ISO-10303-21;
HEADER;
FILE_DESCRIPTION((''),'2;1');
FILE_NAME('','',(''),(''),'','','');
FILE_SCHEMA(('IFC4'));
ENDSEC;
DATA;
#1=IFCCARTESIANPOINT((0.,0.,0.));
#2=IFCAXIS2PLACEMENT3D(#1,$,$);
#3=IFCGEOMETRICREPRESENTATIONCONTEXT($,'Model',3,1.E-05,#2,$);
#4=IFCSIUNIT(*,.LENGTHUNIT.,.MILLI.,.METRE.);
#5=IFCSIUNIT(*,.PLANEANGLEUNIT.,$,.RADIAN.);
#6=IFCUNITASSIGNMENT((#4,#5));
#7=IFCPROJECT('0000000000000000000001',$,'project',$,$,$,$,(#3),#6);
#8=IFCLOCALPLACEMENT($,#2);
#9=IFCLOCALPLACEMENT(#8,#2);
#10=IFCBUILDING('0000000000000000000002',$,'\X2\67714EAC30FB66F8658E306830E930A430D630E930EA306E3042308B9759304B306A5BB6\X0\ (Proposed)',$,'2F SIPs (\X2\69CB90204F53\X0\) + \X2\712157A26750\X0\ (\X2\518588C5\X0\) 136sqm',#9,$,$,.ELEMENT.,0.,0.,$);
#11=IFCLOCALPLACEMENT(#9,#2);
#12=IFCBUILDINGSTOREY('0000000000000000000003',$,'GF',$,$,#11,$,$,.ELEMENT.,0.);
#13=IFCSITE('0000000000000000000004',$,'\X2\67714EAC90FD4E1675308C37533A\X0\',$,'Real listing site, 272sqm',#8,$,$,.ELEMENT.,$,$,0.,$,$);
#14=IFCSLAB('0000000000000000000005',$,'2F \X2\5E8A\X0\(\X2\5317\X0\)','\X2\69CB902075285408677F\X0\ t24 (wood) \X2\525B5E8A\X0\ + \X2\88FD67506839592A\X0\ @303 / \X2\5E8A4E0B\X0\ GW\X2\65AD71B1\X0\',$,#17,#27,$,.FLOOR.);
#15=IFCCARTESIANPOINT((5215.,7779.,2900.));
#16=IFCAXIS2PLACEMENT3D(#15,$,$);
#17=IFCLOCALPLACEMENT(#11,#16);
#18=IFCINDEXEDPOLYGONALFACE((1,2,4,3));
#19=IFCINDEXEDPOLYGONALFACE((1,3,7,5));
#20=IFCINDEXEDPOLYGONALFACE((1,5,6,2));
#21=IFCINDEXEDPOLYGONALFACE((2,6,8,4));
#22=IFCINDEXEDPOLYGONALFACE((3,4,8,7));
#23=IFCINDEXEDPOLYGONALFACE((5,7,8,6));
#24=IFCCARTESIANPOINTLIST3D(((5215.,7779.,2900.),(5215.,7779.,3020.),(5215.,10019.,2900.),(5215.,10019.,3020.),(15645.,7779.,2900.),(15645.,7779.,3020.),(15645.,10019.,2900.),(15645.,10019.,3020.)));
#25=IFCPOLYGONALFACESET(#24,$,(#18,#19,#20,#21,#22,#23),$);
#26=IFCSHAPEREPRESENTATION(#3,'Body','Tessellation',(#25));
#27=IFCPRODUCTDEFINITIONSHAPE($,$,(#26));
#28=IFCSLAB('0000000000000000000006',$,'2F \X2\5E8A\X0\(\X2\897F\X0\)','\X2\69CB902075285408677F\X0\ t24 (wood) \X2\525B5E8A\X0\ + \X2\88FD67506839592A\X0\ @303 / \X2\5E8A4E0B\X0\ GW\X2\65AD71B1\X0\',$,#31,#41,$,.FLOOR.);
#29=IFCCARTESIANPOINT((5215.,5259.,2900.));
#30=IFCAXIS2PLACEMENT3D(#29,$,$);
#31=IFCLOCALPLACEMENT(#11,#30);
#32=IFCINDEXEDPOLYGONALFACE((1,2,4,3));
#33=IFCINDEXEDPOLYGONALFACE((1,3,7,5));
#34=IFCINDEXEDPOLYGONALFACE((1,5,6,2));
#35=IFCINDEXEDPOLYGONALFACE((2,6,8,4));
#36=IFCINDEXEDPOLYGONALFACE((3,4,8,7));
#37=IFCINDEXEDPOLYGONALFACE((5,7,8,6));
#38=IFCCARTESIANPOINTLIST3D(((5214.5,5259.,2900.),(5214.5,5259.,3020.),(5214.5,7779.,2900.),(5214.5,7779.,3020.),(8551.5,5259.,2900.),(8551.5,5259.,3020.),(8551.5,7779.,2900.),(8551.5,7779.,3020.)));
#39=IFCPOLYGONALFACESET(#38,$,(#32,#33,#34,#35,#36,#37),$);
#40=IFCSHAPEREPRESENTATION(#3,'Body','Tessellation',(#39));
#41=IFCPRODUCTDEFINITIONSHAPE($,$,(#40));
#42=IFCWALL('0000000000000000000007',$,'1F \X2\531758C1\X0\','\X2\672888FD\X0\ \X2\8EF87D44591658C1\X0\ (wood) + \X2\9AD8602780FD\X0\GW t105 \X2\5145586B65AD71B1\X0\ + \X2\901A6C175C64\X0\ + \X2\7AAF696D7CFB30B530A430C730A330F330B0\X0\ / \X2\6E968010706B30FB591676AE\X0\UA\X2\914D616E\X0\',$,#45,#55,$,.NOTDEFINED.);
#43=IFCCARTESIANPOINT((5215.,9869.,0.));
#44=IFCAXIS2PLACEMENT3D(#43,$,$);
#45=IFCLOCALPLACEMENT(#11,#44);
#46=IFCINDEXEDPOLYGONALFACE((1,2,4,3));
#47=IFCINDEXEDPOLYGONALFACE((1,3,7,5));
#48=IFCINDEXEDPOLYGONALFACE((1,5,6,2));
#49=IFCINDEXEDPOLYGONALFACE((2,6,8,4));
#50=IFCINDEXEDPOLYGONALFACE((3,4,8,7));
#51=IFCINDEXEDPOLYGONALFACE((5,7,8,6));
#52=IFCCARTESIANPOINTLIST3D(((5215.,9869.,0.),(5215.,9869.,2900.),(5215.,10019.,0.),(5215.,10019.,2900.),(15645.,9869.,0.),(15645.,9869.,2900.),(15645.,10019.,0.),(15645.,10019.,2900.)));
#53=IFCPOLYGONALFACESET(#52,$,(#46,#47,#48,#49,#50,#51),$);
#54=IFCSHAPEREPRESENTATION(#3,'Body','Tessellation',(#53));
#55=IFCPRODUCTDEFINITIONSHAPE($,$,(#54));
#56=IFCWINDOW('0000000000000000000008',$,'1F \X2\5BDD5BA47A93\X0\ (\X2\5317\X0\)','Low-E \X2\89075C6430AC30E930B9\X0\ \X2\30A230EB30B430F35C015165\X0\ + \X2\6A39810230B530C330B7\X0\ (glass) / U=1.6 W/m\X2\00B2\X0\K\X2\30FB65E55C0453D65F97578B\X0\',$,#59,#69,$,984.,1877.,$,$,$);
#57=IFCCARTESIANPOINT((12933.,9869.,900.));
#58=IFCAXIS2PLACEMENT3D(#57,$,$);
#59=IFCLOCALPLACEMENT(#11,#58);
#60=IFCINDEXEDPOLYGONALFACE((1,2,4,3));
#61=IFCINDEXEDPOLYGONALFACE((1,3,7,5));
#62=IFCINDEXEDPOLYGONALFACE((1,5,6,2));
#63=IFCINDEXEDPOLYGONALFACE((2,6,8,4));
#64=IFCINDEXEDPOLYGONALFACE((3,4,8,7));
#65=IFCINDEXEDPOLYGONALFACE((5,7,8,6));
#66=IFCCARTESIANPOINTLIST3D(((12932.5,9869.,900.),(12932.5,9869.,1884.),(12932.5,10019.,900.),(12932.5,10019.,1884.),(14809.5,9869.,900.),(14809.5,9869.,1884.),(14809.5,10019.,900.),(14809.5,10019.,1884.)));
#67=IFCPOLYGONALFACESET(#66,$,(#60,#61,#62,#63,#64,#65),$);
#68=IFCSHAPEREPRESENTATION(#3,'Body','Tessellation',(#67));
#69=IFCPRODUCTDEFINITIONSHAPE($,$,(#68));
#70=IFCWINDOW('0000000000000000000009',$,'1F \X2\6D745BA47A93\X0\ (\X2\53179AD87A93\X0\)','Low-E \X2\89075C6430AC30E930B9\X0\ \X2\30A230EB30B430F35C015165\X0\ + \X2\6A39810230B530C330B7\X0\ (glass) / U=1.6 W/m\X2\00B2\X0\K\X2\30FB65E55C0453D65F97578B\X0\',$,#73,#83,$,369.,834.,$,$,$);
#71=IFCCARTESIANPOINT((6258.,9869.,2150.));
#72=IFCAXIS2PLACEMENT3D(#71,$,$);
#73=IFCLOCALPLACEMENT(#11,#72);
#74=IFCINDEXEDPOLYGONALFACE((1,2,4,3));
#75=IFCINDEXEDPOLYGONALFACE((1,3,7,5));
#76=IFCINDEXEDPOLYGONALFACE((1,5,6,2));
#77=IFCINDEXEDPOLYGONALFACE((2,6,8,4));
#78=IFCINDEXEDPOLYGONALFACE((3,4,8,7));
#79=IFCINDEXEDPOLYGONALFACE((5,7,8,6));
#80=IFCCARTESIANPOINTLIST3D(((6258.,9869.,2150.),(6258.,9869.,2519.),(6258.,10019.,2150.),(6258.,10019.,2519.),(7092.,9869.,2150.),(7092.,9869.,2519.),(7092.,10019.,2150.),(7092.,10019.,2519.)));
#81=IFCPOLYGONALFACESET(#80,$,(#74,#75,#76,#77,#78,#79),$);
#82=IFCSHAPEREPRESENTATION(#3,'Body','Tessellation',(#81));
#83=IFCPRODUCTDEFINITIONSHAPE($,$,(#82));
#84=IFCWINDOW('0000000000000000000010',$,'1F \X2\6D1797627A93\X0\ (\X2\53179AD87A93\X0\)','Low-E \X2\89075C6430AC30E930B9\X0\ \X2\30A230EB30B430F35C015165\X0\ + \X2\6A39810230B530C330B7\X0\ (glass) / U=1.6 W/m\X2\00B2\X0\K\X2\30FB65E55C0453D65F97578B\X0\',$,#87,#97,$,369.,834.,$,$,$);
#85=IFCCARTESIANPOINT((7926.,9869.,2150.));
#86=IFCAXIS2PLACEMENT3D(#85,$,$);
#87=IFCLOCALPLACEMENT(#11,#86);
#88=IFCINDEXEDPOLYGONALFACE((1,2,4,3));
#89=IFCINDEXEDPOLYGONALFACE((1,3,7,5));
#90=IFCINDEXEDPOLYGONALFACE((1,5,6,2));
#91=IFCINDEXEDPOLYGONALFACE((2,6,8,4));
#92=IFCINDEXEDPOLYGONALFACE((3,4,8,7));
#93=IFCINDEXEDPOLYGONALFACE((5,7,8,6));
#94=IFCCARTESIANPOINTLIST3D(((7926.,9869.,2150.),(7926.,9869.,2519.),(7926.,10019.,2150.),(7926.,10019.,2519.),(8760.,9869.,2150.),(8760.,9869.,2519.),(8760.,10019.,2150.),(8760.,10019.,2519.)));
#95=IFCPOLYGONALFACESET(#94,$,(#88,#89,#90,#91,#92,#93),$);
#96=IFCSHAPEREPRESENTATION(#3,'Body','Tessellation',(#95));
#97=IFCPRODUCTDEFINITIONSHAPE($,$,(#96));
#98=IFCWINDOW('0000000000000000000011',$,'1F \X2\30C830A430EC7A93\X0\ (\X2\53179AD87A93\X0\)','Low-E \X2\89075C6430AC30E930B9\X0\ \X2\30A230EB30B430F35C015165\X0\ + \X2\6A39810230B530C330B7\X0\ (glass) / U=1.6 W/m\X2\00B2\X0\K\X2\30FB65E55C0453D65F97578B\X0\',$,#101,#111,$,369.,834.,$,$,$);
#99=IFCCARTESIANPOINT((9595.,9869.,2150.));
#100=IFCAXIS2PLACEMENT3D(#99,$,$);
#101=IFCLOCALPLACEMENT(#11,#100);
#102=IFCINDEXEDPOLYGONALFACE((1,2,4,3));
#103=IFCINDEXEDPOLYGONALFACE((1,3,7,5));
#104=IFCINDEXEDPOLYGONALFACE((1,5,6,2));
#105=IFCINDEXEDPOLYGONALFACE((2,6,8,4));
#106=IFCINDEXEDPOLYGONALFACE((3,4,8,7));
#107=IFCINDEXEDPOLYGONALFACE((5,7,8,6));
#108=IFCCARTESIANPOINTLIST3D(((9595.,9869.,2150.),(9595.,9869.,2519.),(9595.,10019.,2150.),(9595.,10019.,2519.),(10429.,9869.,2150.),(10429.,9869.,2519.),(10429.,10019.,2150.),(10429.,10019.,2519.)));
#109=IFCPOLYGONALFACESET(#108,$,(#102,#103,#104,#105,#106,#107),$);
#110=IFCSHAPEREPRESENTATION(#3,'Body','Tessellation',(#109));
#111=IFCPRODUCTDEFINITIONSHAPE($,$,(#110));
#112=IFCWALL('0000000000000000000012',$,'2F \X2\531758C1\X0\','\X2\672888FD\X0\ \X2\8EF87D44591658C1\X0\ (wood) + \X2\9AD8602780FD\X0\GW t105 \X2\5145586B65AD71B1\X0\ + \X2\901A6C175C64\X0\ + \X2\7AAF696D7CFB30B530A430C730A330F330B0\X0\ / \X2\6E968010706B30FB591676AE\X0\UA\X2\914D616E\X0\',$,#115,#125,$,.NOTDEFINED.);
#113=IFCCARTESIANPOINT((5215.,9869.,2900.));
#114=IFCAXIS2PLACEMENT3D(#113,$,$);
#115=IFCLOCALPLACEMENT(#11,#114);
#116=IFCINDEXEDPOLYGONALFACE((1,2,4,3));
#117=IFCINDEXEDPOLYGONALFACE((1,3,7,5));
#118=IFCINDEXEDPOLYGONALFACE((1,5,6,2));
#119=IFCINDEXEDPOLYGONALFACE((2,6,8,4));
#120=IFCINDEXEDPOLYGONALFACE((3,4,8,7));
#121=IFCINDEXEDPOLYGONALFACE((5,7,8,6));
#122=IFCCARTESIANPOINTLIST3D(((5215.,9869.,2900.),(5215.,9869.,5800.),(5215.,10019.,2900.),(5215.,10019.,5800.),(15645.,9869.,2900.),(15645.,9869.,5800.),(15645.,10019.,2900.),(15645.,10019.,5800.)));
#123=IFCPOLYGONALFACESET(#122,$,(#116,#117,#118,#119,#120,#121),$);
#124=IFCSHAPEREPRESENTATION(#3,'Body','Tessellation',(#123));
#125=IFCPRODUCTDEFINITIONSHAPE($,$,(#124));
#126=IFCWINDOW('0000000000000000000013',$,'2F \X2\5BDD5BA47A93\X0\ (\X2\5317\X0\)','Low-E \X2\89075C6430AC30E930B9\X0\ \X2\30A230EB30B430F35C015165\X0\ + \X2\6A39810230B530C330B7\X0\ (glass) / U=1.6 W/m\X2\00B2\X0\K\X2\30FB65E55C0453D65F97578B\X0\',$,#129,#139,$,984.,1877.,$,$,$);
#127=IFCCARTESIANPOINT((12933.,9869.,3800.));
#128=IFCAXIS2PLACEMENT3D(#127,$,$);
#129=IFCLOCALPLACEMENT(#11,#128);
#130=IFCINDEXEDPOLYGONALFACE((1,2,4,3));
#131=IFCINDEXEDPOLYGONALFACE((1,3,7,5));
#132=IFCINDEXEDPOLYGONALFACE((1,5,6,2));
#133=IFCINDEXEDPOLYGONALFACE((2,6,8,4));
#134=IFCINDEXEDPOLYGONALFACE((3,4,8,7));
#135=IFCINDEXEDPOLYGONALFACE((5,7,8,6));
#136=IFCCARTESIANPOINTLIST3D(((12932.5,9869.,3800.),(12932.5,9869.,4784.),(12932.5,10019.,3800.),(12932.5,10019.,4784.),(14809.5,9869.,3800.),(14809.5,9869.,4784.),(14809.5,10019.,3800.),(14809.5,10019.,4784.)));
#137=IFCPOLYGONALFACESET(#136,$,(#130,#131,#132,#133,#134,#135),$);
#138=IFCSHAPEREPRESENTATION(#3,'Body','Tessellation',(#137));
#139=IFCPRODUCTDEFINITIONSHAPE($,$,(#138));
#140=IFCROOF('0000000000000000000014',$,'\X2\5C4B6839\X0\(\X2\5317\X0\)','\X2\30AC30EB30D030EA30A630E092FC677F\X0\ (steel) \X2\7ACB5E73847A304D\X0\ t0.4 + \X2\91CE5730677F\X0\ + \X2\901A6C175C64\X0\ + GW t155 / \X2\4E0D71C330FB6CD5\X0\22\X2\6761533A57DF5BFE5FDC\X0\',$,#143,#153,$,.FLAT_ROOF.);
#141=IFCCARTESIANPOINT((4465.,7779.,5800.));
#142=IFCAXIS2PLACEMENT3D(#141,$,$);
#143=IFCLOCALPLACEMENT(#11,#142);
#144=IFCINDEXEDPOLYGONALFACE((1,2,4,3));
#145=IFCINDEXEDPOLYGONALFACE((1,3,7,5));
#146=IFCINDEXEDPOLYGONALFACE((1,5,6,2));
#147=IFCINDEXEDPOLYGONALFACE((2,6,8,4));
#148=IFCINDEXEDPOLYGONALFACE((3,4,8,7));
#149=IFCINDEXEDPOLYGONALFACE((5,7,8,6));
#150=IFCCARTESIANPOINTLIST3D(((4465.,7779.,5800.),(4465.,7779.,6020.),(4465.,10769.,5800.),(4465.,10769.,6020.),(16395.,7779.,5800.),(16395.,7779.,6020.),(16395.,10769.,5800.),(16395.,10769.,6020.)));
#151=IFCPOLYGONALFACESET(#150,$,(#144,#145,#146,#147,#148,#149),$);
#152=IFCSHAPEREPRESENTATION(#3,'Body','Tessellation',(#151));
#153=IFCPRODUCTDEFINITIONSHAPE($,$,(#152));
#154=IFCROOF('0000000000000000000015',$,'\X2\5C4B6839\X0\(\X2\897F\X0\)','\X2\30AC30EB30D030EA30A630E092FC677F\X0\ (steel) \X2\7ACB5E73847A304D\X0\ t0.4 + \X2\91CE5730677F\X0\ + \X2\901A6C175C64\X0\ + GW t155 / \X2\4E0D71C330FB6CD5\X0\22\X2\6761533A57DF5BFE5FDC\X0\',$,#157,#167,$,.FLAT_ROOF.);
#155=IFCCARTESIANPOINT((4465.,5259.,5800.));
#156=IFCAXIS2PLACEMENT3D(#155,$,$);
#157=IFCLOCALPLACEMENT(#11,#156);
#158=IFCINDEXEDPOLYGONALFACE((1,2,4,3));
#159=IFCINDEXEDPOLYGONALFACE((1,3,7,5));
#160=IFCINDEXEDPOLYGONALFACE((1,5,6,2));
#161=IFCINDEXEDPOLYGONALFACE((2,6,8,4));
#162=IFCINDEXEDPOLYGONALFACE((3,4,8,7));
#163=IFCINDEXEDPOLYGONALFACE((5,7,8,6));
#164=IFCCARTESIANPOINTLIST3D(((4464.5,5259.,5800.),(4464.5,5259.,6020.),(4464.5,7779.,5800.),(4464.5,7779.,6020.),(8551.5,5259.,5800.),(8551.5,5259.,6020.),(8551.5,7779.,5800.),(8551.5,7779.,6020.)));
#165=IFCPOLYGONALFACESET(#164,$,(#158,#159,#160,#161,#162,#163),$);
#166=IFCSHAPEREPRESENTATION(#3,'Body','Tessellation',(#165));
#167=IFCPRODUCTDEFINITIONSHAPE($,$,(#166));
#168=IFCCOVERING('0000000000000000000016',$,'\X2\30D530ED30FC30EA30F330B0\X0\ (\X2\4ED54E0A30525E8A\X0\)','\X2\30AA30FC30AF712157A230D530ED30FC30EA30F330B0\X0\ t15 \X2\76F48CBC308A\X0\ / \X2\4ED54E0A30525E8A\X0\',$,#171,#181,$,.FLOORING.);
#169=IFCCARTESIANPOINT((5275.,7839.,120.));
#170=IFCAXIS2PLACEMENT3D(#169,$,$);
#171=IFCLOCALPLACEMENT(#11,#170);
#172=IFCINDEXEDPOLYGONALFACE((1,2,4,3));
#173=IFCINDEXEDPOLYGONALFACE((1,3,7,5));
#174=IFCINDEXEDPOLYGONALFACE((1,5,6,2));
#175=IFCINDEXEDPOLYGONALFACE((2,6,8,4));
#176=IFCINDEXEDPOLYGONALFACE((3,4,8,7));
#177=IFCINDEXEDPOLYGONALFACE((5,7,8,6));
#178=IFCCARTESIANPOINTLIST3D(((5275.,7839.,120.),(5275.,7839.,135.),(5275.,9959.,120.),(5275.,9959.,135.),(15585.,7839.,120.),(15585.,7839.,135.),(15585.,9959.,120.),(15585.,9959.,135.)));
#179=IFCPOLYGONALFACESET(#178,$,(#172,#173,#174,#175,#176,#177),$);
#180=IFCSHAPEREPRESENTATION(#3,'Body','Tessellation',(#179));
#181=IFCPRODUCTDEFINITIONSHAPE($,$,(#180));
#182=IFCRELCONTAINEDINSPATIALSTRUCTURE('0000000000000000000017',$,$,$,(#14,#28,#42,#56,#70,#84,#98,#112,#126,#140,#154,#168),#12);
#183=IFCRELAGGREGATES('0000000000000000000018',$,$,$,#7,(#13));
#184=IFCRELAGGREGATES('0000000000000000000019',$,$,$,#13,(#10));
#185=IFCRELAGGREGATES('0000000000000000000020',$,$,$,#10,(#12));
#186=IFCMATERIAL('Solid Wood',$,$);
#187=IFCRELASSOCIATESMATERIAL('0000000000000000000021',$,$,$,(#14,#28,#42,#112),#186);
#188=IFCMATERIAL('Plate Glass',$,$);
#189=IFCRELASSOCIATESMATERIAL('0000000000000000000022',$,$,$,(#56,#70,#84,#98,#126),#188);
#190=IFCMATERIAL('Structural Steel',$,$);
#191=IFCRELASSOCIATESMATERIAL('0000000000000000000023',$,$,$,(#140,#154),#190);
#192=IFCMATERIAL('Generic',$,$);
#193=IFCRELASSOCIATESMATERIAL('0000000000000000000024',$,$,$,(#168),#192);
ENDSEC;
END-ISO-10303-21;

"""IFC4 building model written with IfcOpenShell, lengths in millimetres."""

from ifc_helpers import new_model, si_unit, frame, frame_2d, origin, place, context, project, spatial, rectangle, extrude, material, element, fill, save


model = new_model("IFC4")

# Units and contexts
model_context = context("Model", 3, precision=1e-05, world=origin())
ifc_project = project(units=[si_unit("LENGTHUNIT", "METRE", prefix="MILLI"), si_unit("PLANEANGLEUNIT", "RADIAN")], contexts=[model_context])

# Site, building, storey
site_placement = place(None, origin())
site = spatial("IfcSite", under=ifc_project, at=site_placement, Name="東京都世田谷区", ObjectType="Real listing site, 272sqm", CompositionType="ELEMENT", RefElevation=0.0)
building_placement = place(site_placement, origin())
building = spatial("IfcBuilding", under=site, at=building_placement, Name="東京・書斎とライブラリのある静かな家 (Proposed)", ObjectType="2F SIPs (構造体) + 無垢材 (内装) 136sqm", CompositionType="ELEMENT", ElevationOfRefHeight=0.0, ElevationOfTerrain=0.0)
storey_placement = place(building_placement, origin())
storey = spatial("IfcBuildingStorey", under=building, at=storey_placement, Name="GF", CompositionType="ELEMENT", Elevation=0.0)

# Slabs
ifc_material_1 = material(Name="Solid Wood")
slab_1_placement = place(storey_placement, frame((5215.0, 7779.0, 2900.0)))
element("IfcSlab", 1, at=slab_1_placement, inside=storey, material=ifc_material_1, Name="2F 床(北)", Description="構造用合板 t24 (wood) 剛床 + 製材根太 @303 / 床下 GW断熱", PredefinedType="FLOOR", context=model_context, shape_type="SweptSolid", body=[
    extrude(rectangle(XDim=10430.0, YDim=2240.0, at=frame_2d((5215.0, 1120.0))), frame((5215.0, 7779.0, 2900.0)), (0.0, 0.0, 1.0), 120.0),
])
slab_2_placement = place(storey_placement, frame((5215.0, 5259.0, 2900.0)))
element("IfcSlab", 2, at=slab_2_placement, inside=storey, material=ifc_material_1, Name="2F 床(西)", Description="構造用合板 t24 (wood) 剛床 + 製材根太 @303 / 床下 GW断熱", PredefinedType="FLOOR", context=model_context, shape_type="SweptSolid", body=[
    extrude(rectangle(XDim=3337.0, YDim=2520.0, at=frame_2d((1668.0, 1260.0))), frame((5215.0, 5259.0, 2900.0)), (0.0, 0.0, 1.0), 120.0),
])

# Wall, openings, windows
wall_1_placement = place(storey_placement, frame((5215.0, 9869.0, 0.0)))
wall_1 = element("IfcWall", 3, at=wall_1_placement, inside=storey, material=ifc_material_1, Name="1F 北壁", Description="木製 軸組外壁 (wood) + 高性能GW t105 充填断熱 + 通気層 + 窯業系サイディング / 準耐火・外皮UA配慮", PredefinedType="NOTDEFINED", context=model_context, shape_type="SweptSolid", body=[
    extrude(rectangle(XDim=10430.0, YDim=150.0, at=frame_2d((5215.0, 75.0))), frame((5215.0, 9869.0, 0.0)), (0.0, 0.0, 1.0), 2900.0),
])
opening_1_placement = place(storey_placement, frame((12933.0, 9869.0, 900.0)))
opening_1 = element("IfcOpeningElement", 4, at=opening_1_placement, cuts=wall_1, PredefinedType="NOTDEFINED", context=model_context, shape_type="SweptSolid", body=[
    extrude(rectangle(XDim=1877.0, YDim=150.0, at=frame_2d((938.0, 75.0))), frame((12933.0, 9869.0, 900.0)), (0.0, 0.0, 1.0), 984.0),
])
opening_2_placement = place(storey_placement, frame((6258.0, 9869.0, 2150.0)))
opening_2 = element("IfcOpeningElement", 5, at=opening_2_placement, cuts=wall_1, PredefinedType="NOTDEFINED", context=model_context, shape_type="SweptSolid", body=[
    extrude(rectangle(XDim=834.0, YDim=150.0, at=frame_2d((417.0, 75.0))), frame((6258.0, 9869.0, 2150.0)), (0.0, 0.0, 1.0), 369.0),
])
opening_3_placement = place(storey_placement, frame((7926.0, 9869.0, 2150.0)))
opening_3 = element("IfcOpeningElement", 6, at=opening_3_placement, cuts=wall_1, PredefinedType="NOTDEFINED", context=model_context, shape_type="SweptSolid", body=[
    extrude(rectangle(XDim=834.0, YDim=150.0, at=frame_2d((417.0, 75.0))), frame((7926.0, 9869.0, 2150.0)), (0.0, 0.0, 1.0), 369.0),
])
opening_4_placement = place(storey_placement, frame((9595.0, 9869.0, 2150.0)))
opening_4 = element("IfcOpeningElement", 7, at=opening_4_placement, cuts=wall_1, PredefinedType="NOTDEFINED", context=model_context, shape_type="SweptSolid", body=[
    extrude(rectangle(XDim=834.0, YDim=150.0, at=frame_2d((417.0, 75.0))), frame((9595.0, 9869.0, 2150.0)), (0.0, 0.0, 1.0), 369.0),
])
ifc_material_2 = material(Name="Plate Glass")
window_1_placement = place(storey_placement, frame((12933.0, 9869.0, 900.0)))
window_1 = element("IfcWindow", 8, at=window_1_placement, inside=storey, material=ifc_material_2, Name="1F 寝室窓 (北)", Description="Low-E 複層ガラス アルゴン封入 + 樹脂サッシ (glass) / U=1.6 W/m²K・日射取得型", OverallHeight=984.0, OverallWidth=1877.0, context=model_context, shape_type="SweptSolid", body=[
    extrude(rectangle(XDim=1877.0, YDim=150.0, at=frame_2d((938.0, 75.0))), frame((12933.0, 9869.0, 900.0)), (0.0, 0.0, 1.0), 984.0),
])
fill(opening_1, window_1)
window_2_placement = place(storey_placement, frame((6258.0, 9869.0, 2150.0)))
window_2 = element("IfcWindow", 9, at=window_2_placement, inside=storey, material=ifc_material_2, Name="1F 浴室窓 (北高窓)", Description="Low-E 複層ガラス アルゴン封入 + 樹脂サッシ (glass) / U=1.6 W/m²K・日射取得型", OverallHeight=369.0, OverallWidth=834.0, context=model_context, shape_type="SweptSolid", body=[
    extrude(rectangle(XDim=834.0, YDim=150.0, at=frame_2d((417.0, 75.0))), frame((6258.0, 9869.0, 2150.0)), (0.0, 0.0, 1.0), 369.0),
])
fill(opening_2, window_2)
window_3_placement = place(storey_placement, frame((7926.0, 9869.0, 2150.0)))
window_3 = element("IfcWindow", 10, at=window_3_placement, inside=storey, material=ifc_material_2, Name="1F 洗面窓 (北高窓)", Description="Low-E 複層ガラス アルゴン封入 + 樹脂サッシ (glass) / U=1.6 W/m²K・日射取得型", OverallHeight=369.0, OverallWidth=834.0, context=model_context, shape_type="SweptSolid", body=[
    extrude(rectangle(XDim=834.0, YDim=150.0, at=frame_2d((417.0, 75.0))), frame((7926.0, 9869.0, 2150.0)), (0.0, 0.0, 1.0), 369.0),
])
fill(opening_3, window_3)
window_4_placement = place(storey_placement, frame((9595.0, 9869.0, 2150.0)))
window_4 = element("IfcWindow", 11, at=window_4_placement, inside=storey, material=ifc_material_2, Name="1F トイレ窓 (北高窓)", Description="Low-E 複層ガラス アルゴン封入 + 樹脂サッシ (glass) / U=1.6 W/m²K・日射取得型", OverallHeight=369.0, OverallWidth=834.0, context=model_context, shape_type="SweptSolid", body=[
    extrude(rectangle(XDim=834.0, YDim=150.0, at=frame_2d((417.0, 75.0))), frame((9595.0, 9869.0, 2150.0)), (0.0, 0.0, 1.0), 369.0),
])
fill(opening_4, window_4)

# Wall, opening, window
wall_2_placement = place(storey_placement, frame((5215.0, 9869.0, 2900.0)))
wall_2 = element("IfcWall", 12, at=wall_2_placement, inside=storey, material=ifc_material_1, Name="2F 北壁", Description="木製 軸組外壁 (wood) + 高性能GW t105 充填断熱 + 通気層 + 窯業系サイディング / 準耐火・外皮UA配慮", PredefinedType="NOTDEFINED", context=model_context, shape_type="SweptSolid", body=[
    extrude(rectangle(XDim=10430.0, YDim=150.0, at=frame_2d((5215.0, 75.0))), frame((5215.0, 9869.0, 2900.0)), (0.0, 0.0, 1.0), 2900.0),
])
opening_5_placement = place(storey_placement, frame((12933.0, 9869.0, 3800.0)))
opening_5 = element("IfcOpeningElement", 13, at=opening_5_placement, cuts=wall_2, PredefinedType="NOTDEFINED", context=model_context, shape_type="SweptSolid", body=[
    extrude(rectangle(XDim=1877.0, YDim=150.0, at=frame_2d((938.0, 75.0))), frame((12933.0, 9869.0, 3800.0)), (0.0, 0.0, 1.0), 984.0),
])
window_5_placement = place(storey_placement, frame((12933.0, 9869.0, 3800.0)))
window_5 = element("IfcWindow", 14, at=window_5_placement, inside=storey, material=ifc_material_2, Name="2F 寝室窓 (北)", Description="Low-E 複層ガラス アルゴン封入 + 樹脂サッシ (glass) / U=1.6 W/m²K・日射取得型", OverallHeight=984.0, OverallWidth=1877.0, context=model_context, shape_type="SweptSolid", body=[
    extrude(rectangle(XDim=1877.0, YDim=150.0, at=frame_2d((938.0, 75.0))), frame((12933.0, 9869.0, 3800.0)), (0.0, 0.0, 1.0), 984.0),
])
fill(opening_5, window_5)

# Roofs
ifc_material_3 = material(Name="Structural Steel")
for number, where, name in (
    (15, (4465.0, 7779.0, 5800.0), "屋根(北)"),
):
    element("IfcRoof", number, at=place(storey_placement, frame(where)), inside=storey, material=ifc_material_3, Name=name, Description="ガルバリウム鋼板 (steel) 立平葺き t0.4 + 野地板 + 通気層 + GW t155 / 不燃・法22条区域対応", PredefinedType="FLAT_ROOF", context=model_context, shape_type="SweptSolid", body=[
        extrude(rectangle(XDim=11930.0, YDim=2990.0, at=frame_2d((5965.0, 1495.0))), frame((4465.0, 7779.0, 5800.0)), (0.0, 0.0, 1.0), 220.0),
    ])
roof_placement = place(storey_placement, frame((4465.0, 5259.0, 5800.0)))
element("IfcRoof", 16, at=roof_placement, inside=storey, material=ifc_material_3, Name="屋根(西)", Description="ガルバリウム鋼板 (steel) 立平葺き t0.4 + 野地板 + 通気層 + GW t155 / 不燃・法22条区域対応", PredefinedType="FLAT_ROOF", context=model_context, shape_type="SweptSolid", body=[
    extrude(rectangle(XDim=4087.0, YDim=2520.0, at=frame_2d((2043.0, 1260.0))), frame((4465.0, 5259.0, 5800.0)), (0.0, 0.0, 1.0), 220.0),
])

# Covering
ifc_material_4 = material(Name="Generic")
covering_1_placement = place(storey_placement, frame((5275.0, 7839.0, 120.0)))
element("IfcCovering", 17, at=covering_1_placement, inside=storey, material=ifc_material_4, Name="フローリング (仕上げ床)", Description="オーク無垢フローリング t15 直貼り / 仕上げ床", PredefinedType="FLOORING", context=model_context, shape_type="SweptSolid", body=[
    extrude(rectangle(XDim=10310.0, YDim=2120.0, at=frame_2d((5155.0, 1060.0))), frame((5275.0, 7839.0, 120.0)), (0.0, 0.0, 1.0), 15.0),
])

save(model, "model.ifc")
